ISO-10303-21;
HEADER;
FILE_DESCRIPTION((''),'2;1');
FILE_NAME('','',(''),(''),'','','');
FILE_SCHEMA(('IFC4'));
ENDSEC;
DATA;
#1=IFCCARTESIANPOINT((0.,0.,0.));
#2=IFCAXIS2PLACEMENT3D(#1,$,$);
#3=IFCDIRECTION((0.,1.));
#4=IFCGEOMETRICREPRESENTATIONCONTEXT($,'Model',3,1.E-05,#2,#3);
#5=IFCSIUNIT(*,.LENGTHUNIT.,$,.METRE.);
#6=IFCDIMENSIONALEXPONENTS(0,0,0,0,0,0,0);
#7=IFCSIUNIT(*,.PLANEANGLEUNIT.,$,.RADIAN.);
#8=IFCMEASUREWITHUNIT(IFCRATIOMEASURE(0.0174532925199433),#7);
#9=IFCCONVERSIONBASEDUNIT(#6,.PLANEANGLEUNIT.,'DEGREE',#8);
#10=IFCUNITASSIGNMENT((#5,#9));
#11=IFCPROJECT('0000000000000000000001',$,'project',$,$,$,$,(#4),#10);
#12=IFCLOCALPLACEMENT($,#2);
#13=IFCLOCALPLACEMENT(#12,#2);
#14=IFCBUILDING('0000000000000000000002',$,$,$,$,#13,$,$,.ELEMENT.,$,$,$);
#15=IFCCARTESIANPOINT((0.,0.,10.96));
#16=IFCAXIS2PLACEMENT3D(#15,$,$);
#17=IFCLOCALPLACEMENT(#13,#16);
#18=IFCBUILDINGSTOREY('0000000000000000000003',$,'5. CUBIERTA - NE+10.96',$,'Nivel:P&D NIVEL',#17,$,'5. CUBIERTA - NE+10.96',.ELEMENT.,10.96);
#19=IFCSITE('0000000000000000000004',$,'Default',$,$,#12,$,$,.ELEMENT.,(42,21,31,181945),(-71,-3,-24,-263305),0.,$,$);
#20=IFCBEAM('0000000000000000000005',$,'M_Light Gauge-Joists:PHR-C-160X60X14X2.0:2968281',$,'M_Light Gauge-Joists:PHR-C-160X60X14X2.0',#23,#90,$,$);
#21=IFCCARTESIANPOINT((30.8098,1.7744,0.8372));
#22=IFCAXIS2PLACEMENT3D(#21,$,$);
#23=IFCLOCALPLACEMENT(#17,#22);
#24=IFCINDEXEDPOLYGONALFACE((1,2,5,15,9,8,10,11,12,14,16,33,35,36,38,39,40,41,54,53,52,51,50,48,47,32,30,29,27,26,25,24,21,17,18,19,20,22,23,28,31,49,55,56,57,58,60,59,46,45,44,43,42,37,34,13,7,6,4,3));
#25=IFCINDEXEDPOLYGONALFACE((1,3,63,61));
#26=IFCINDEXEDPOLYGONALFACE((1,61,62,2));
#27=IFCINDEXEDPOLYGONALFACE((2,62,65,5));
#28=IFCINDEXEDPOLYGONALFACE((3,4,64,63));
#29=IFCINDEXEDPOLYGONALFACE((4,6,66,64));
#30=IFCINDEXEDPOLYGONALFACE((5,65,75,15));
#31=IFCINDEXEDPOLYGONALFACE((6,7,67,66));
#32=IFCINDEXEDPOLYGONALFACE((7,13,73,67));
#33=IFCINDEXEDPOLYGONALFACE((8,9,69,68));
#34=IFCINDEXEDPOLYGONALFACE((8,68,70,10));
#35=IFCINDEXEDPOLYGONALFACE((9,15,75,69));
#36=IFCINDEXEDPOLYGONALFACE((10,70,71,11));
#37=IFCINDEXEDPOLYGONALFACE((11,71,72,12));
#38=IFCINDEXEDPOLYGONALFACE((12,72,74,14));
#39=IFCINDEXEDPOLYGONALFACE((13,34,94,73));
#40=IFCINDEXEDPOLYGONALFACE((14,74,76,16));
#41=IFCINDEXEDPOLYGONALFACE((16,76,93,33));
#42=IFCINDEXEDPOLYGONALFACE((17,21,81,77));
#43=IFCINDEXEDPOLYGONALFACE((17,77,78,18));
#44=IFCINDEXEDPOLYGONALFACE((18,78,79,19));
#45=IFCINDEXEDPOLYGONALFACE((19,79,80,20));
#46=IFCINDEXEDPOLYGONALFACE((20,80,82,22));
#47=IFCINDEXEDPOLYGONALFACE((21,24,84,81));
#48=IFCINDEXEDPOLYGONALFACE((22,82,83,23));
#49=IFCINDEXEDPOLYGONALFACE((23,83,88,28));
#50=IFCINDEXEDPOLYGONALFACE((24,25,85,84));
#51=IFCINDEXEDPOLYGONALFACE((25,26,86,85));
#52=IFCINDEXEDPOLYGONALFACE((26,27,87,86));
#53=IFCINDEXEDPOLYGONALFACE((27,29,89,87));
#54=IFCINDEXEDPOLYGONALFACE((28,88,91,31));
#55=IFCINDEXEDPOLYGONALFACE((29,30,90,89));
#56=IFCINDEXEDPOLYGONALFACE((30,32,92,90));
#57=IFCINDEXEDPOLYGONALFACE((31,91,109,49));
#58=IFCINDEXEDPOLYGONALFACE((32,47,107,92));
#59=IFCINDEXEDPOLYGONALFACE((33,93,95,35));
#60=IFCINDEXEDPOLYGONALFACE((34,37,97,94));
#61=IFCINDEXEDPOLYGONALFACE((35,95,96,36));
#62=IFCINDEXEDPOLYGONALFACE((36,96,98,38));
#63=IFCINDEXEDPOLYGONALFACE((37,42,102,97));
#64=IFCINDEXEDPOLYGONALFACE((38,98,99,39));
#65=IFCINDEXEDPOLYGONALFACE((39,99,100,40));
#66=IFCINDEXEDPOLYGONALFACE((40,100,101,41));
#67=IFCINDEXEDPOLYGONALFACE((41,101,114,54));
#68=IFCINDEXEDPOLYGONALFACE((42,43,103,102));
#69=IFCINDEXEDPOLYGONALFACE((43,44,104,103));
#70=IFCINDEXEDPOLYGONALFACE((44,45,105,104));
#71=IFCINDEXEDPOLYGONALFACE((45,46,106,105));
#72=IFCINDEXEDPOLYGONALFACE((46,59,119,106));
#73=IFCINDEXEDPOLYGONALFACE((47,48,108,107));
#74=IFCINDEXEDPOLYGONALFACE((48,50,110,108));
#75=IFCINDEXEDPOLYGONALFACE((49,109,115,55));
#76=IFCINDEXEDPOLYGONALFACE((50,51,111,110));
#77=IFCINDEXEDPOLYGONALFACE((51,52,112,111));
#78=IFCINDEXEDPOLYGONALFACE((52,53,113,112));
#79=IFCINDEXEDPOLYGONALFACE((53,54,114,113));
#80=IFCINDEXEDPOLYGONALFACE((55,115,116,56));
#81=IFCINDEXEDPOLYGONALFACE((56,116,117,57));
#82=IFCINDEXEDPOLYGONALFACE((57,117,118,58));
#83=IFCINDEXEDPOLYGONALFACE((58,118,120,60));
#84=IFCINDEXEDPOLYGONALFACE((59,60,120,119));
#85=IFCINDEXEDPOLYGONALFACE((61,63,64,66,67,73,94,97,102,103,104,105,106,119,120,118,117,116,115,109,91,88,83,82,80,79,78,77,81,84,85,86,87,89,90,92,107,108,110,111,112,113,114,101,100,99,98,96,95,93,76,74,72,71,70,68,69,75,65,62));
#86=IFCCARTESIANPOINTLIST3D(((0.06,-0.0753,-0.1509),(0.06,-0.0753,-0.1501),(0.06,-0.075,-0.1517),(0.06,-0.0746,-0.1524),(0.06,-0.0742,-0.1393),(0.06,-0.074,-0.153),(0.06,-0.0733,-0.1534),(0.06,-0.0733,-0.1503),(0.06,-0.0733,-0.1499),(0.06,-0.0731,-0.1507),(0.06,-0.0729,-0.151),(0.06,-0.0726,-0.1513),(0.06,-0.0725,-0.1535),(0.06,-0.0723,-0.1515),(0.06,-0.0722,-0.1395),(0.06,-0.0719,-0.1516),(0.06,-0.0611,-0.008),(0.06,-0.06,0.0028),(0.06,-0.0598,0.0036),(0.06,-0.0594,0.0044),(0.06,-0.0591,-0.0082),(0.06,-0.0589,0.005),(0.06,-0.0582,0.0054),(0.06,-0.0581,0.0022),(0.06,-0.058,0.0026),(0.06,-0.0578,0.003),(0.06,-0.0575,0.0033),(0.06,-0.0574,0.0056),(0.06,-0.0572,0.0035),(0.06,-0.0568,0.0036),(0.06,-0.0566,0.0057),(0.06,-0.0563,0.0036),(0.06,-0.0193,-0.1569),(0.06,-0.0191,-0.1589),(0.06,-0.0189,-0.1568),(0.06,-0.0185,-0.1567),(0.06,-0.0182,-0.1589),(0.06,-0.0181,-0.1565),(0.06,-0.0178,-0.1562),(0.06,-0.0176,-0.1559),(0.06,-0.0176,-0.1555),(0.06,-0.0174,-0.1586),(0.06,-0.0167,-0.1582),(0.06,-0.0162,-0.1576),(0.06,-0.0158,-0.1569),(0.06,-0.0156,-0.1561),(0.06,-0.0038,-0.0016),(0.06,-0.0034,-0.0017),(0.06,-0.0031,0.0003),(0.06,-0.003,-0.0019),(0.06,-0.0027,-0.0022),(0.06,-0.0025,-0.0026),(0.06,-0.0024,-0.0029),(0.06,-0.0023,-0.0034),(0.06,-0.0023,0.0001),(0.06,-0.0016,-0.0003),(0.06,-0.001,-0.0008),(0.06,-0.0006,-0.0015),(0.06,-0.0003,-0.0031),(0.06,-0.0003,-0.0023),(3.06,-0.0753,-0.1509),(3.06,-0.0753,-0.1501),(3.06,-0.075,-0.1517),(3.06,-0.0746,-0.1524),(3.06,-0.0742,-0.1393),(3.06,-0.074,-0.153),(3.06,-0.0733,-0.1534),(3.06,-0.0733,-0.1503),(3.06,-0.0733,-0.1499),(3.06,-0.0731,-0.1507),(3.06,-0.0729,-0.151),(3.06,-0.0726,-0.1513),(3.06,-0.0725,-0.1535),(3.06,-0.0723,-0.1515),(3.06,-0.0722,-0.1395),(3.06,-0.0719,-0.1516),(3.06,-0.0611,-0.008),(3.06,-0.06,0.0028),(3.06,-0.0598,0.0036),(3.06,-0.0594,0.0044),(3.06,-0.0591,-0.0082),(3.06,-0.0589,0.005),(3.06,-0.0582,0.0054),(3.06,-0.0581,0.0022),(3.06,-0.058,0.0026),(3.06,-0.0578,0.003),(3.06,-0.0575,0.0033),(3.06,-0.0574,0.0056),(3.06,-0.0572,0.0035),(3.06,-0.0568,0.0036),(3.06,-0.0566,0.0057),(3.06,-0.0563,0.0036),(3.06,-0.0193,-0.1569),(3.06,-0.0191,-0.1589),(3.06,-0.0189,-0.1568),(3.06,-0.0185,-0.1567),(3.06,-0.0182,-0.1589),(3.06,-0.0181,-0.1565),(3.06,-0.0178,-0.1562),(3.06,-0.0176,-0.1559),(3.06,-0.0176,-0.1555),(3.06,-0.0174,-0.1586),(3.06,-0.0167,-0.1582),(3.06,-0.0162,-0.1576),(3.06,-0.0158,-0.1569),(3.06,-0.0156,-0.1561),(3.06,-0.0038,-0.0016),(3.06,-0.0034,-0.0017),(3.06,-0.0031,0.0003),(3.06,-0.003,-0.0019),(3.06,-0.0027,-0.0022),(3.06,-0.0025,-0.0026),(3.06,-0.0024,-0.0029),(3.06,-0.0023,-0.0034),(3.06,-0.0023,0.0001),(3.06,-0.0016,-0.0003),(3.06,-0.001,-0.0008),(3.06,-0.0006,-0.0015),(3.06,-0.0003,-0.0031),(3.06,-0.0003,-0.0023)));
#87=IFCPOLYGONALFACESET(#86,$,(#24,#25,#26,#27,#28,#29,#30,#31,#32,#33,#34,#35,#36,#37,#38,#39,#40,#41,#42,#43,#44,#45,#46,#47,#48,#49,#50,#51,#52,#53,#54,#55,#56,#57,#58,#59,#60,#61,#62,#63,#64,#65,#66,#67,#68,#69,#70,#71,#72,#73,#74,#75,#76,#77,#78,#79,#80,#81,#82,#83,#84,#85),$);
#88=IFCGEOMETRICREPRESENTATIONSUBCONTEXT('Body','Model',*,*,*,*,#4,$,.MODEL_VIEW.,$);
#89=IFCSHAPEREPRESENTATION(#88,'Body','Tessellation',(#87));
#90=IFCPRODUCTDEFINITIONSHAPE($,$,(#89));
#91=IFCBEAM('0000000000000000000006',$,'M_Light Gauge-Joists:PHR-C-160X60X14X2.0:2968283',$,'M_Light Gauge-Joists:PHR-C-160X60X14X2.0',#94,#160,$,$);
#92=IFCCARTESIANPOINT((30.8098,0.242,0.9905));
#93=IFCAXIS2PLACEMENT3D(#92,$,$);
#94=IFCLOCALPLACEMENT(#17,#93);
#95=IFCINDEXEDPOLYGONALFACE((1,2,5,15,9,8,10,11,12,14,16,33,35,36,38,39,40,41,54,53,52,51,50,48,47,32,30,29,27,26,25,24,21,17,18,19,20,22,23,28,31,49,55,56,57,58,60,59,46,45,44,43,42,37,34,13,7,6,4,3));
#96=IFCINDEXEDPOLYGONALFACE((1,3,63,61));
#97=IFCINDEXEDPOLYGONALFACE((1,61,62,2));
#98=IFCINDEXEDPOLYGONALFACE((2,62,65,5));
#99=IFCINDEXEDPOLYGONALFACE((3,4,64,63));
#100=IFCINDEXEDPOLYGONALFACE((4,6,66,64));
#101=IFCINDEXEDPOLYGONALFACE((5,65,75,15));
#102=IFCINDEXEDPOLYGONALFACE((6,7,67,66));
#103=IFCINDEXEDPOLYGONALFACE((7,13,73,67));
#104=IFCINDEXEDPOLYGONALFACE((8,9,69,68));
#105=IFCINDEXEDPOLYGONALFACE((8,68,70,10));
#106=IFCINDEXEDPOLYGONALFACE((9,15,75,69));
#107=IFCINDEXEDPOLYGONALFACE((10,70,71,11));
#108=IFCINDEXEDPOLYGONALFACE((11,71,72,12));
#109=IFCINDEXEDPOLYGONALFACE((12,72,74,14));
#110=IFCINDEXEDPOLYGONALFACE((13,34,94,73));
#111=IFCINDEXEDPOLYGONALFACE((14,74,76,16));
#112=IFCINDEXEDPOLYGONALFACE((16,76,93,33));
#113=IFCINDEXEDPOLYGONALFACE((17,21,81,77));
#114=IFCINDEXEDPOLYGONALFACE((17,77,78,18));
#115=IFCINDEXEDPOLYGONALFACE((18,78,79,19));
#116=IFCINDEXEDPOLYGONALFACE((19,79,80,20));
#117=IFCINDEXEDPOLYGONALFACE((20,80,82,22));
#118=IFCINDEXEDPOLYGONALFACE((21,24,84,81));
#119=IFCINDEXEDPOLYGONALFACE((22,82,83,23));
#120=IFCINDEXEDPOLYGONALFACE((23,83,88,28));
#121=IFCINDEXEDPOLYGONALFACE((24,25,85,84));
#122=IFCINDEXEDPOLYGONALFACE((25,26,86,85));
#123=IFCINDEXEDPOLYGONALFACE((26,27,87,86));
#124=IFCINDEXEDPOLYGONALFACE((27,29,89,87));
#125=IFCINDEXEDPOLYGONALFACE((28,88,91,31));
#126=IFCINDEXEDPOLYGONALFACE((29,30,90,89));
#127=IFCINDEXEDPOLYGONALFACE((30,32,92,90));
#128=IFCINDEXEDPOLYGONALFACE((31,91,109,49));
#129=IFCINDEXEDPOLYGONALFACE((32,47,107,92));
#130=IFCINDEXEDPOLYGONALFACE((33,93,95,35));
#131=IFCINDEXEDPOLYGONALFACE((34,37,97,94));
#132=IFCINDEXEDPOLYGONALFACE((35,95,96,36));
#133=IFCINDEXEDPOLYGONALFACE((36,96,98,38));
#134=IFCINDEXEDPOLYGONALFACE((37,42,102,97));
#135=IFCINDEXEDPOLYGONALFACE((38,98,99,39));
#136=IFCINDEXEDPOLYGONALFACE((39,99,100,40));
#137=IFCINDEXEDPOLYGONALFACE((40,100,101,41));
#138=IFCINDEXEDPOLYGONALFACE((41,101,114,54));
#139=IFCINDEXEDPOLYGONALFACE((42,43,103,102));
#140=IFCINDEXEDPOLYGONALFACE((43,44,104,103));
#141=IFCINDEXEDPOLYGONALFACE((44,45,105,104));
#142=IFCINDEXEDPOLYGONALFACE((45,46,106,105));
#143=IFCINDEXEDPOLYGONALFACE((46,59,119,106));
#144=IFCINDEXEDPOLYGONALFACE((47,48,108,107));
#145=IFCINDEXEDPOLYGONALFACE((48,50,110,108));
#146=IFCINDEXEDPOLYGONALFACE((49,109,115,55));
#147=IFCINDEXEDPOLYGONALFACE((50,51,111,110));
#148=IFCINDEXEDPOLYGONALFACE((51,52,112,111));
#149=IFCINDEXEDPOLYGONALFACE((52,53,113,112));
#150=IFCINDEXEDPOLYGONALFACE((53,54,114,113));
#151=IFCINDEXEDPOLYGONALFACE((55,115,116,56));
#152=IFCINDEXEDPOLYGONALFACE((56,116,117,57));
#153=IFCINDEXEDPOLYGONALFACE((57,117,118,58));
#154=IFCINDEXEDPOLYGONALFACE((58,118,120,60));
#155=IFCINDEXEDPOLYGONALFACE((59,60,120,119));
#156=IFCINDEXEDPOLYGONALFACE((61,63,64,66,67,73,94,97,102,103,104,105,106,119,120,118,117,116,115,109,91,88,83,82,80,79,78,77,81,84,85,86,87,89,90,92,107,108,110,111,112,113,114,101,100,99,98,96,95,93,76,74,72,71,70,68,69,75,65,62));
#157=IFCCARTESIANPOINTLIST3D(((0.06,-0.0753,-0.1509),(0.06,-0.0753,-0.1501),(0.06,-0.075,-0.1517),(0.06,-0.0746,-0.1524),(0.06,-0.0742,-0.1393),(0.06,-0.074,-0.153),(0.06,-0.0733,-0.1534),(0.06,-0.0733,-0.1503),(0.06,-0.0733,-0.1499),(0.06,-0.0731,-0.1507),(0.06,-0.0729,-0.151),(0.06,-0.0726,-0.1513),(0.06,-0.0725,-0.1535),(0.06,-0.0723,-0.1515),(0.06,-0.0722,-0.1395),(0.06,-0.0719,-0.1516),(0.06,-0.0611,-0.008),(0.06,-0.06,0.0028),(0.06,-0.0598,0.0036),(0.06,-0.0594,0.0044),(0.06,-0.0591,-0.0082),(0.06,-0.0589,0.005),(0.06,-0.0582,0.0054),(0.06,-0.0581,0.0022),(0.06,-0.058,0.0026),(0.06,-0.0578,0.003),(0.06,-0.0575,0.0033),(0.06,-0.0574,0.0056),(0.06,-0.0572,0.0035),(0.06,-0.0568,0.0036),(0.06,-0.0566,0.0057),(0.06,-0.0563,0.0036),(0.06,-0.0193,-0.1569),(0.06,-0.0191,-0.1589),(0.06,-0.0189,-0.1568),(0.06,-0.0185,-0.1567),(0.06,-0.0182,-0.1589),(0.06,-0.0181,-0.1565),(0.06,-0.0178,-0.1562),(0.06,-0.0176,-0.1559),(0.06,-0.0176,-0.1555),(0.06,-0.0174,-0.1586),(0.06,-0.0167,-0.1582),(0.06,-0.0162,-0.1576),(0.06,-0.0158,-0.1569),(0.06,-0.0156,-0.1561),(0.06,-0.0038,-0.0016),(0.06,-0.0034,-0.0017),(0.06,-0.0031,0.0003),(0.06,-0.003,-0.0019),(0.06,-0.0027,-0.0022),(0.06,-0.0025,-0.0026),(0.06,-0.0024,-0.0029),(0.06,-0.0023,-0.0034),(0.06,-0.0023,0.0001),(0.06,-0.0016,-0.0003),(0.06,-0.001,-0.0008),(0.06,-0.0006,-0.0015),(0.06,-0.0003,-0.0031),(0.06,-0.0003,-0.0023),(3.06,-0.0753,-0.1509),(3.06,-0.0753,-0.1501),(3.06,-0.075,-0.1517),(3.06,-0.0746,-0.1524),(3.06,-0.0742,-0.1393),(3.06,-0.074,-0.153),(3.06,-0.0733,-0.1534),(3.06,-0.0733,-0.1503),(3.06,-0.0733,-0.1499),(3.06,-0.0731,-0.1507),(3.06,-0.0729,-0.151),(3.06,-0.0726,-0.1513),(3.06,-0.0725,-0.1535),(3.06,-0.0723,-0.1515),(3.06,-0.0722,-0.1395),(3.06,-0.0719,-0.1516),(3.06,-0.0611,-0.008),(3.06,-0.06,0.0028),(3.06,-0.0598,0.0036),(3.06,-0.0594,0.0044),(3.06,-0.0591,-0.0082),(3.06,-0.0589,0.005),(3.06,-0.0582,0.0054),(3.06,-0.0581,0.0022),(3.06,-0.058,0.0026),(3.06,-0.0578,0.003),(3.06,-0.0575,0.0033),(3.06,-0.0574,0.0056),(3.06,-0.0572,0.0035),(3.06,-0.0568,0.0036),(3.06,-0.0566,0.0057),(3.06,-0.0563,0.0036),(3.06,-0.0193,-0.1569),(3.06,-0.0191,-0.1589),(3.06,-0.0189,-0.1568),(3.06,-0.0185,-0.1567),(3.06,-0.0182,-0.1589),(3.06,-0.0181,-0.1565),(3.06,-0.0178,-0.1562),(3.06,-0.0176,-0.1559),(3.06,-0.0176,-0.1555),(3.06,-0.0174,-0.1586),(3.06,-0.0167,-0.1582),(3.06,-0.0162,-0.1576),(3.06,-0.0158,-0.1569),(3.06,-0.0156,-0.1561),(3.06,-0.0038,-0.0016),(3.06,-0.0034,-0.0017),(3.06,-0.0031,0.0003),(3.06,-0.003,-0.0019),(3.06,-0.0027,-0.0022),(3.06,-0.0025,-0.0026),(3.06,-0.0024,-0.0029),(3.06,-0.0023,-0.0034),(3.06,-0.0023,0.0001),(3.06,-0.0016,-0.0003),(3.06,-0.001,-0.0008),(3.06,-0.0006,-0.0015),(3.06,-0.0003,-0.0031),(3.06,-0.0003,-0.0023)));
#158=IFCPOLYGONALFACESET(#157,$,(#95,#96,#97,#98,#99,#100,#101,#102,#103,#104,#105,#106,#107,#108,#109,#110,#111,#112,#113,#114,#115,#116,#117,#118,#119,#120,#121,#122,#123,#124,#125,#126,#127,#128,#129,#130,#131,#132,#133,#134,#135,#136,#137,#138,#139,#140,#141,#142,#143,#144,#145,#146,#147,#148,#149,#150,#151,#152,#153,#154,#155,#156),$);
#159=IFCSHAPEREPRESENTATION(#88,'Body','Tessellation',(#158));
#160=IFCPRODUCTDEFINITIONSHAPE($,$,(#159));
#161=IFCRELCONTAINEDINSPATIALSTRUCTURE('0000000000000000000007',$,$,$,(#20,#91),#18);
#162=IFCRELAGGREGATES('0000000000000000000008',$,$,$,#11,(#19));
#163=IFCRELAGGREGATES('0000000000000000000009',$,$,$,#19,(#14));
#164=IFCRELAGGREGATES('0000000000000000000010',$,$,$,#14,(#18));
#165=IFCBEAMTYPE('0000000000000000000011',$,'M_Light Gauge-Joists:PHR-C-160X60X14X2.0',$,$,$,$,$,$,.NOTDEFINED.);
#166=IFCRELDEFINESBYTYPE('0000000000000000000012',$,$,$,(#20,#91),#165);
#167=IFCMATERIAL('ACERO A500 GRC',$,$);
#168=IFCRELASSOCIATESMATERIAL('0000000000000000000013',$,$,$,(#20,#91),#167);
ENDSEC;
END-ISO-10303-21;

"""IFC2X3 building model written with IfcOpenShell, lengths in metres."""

from ifc_helpers import new_model, entity, si_unit, converted_unit, direction, frame, frame_2d, origin, place, context, subcontext, project, spatial, polyline, circle_curve, parameter, trimmed, segment, composite_curve, outline, extrude, material, type_object, element, save


model = new_model("IFC2X3")

# Units and contexts
model_context = context("Model", 3, precision=1e-05, world=origin(), true_north=direction((0.0, 1.0)))
body_context = subcontext(model_context, "Body", "Model", "MODEL_VIEW")
ifc_project = project(units=[si_unit("LENGTHUNIT", "METRE"), converted_unit("PLANEANGLEUNIT", "DEGREE", entity("IfcRatioMeasure", 0.0174532925199433), si_unit("PLANEANGLEUNIT", "RADIAN"), dimensions=[0, 0, 0, 0, 0, 0, 0])], contexts=[model_context])

# Site, building, storey
site_placement = place(None, origin())
site = spatial("IfcSite", under=ifc_project, at=site_placement, Name="Default", CompositionType="ELEMENT", RefLatitude=(42, 21, 31, 181945), RefLongitude=(-71, -3, -24, -263305), RefElevation=0.0)
building_placement = place(site_placement, origin())
building = spatial("IfcBuilding", under=site, at=building_placement, CompositionType="ELEMENT")
storey_placement = place(building_placement, frame((0.0, 0.0, 10.96)))
storey = spatial("IfcBuildingStorey", under=building, at=storey_placement, Name="5. CUBIERTA - NE+10.96", ObjectType="Nivel:P&D NIVEL", LongName="5. CUBIERTA - NE+10.96", CompositionType="ELEMENT", Elevation=10.96)

# Beams
ifc_material_1 = material(Name="ACERO A500 GRC")
beam_type_1 = type_object("IfcBeamType", Name="M_Light Gauge-Joists:PHR-C-160X60X14X2.0", PredefinedType="NOTDEFINED")
beam_1_placement = place(storey_placement, frame((30.8098, 1.7744, 0.8372)))
element("IfcBeam", 1, at=beam_1_placement, inside=storey, type_object=beam_type_1, material=ifc_material_1, Name="M_Light Gauge-Joists:PHR-C-160X60X14X2.0:2968281", ObjectType="M_Light Gauge-Joists:PHR-C-160X60X14X2.0", context=body_context, shape_type="SweptSolid", body=[
    extrude(outline(composite_curve([segment(polyline([(-0.0768, -0.0358), (0.0768, -0.0358)]), True, "CONTINUOUS"), segment(trimmed(circle_curve(frame_2d((0.0768, -0.0326), x_axis=(0.0, -1.0)), 0.0032), [parameter(0.0)], [parameter(90.0)], True, "PARAMETER"), True, "CONTINUOUS"), segment(polyline([(0.08, -0.0326), (0.08, 0.021)]), True, "CONTINUOUS"), segment(trimmed(circle_curve(frame_2d((0.0768, 0.021), x_axis=(1.0, 0.0)), 0.0032), [parameter(0.0)], [parameter(90.0)], True, "PARAMETER"), True, "CONTINUOUS"), segment(polyline([(0.0768, 0.0242), (0.066, 0.0242)]), True, "CONTINUOUS"), segment(polyline([(0.066, 0.0242), (0.066, 0.0222)]), True, "CONTINUOUS"), segment(polyline([(0.066, 0.0222), (0.0764, 0.0222)]), True, "CONTINUOUS"), segment(trimmed(circle_curve(frame_2d((0.0764, 0.0206), x_axis=(0.0, 1.0)), 0.0016), [parameter(270.0)], [parameter(0.0)], True, "PARAMETER"), False, "CONTINUOUS"), segment(polyline([(0.078, 0.0206), (0.078, -0.0322)]), True, "CONTINUOUS"), segment(trimmed(circle_curve(frame_2d((0.0764, -0.0322), x_axis=(1.0, 0.0)), 0.0016), [parameter(270.0)], [parameter(0.0)], True, "PARAMETER"), False, "CONTINUOUS"), segment(polyline([(0.0764, -0.0338), (-0.0764, -0.0338)]), True, "CONTINUOUS"), segment(trimmed(circle_curve(frame_2d((-0.0764, -0.0322), x_axis=(0.0, -1.0)), 0.0016), [parameter(270.0)], [parameter(0.0)], True, "PARAMETER"), False, "CONTINUOUS"), segment(polyline([(-0.078, -0.0322), (-0.078, 0.0206)]), True, "CONTINUOUS"), segment(trimmed(circle_curve(frame_2d((-0.0764, 0.0206), x_axis=(-1.0, 0.0)), 0.0016), [parameter(270.0)], [parameter(0.0)], True, "PARAMETER"), False, "CONTINUOUS"), segment(polyline([(-0.0764, 0.0222), (-0.066, 0.0222)]), True, "CONTINUOUS"), segment(polyline([(-0.066, 0.0222), (-0.066, 0.0242)]), True, "CONTINUOUS"), segment(polyline([(-0.066, 0.0242), (-0.0768, 0.0242)]), True, "CONTINUOUS"), segment(trimmed(circle_curve(frame_2d((-0.0768, 0.021), x_axis=(0.0, 1.0)), 0.0032), [parameter(0.0)], [parameter(90.0)], True, "PARAMETER"), True, "CONTINUOUS"), segment(polyline([(-0.08, 0.021), (-0.08, -0.0326)]), True, "CONTINUOUS"), segment(trimmed(circle_curve(frame_2d((-0.0768, -0.0326), x_axis=(-1.0, 0.0)), 0.0032), [parameter(0.0)], [parameter(90.0)], True, "PARAMETER"), True, "CONTINUOUS")], self_intersect=False)), frame((0.06, -0.0436, -0.076), z_axis=(1.0, 0.0, 0.0), x_axis=(0.0, 0.099504, 0.995037)), (0.0, 0.0, 1.0), 3.0),
])
beam_2_placement = place(storey_placement, frame((30.8098, 0.242, 0.9905)))
element("IfcBeam", 2, at=beam_2_placement, inside=storey, type_object=beam_type_1, material=ifc_material_1, Name="M_Light Gauge-Joists:PHR-C-160X60X14X2.0:2968283", ObjectType="M_Light Gauge-Joists:PHR-C-160X60X14X2.0", context=body_context, shape_type="SweptSolid", body=[
    extrude(outline(composite_curve([segment(polyline([(-0.0768, -0.0358), (0.0768, -0.0358)]), True, "CONTINUOUS"), segment(trimmed(circle_curve(frame_2d((0.0768, -0.0326), x_axis=(0.0, -1.0)), 0.0032), [parameter(0.0)], [parameter(90.0)], True, "PARAMETER"), True, "CONTINUOUS"), segment(polyline([(0.08, -0.0326), (0.08, 0.021)]), True, "CONTINUOUS"), segment(trimmed(circle_curve(frame_2d((0.0768, 0.021), x_axis=(1.0, 0.0)), 0.0032), [parameter(0.0)], [parameter(90.0)], True, "PARAMETER"), True, "CONTINUOUS"), segment(polyline([(0.0768, 0.0242), (0.066, 0.0242)]), True, "CONTINUOUS"), segment(polyline([(0.066, 0.0242), (0.066, 0.0222)]), True, "CONTINUOUS"), segment(polyline([(0.066, 0.0222), (0.0764, 0.0222)]), True, "CONTINUOUS"), segment(trimmed(circle_curve(frame_2d((0.0764, 0.0206), x_axis=(0.0, 1.0)), 0.0016), [parameter(270.0)], [parameter(0.0)], True, "PARAMETER"), False, "CONTINUOUS"), segment(polyline([(0.078, 0.0206), (0.078, -0.0322)]), True, "CONTINUOUS"), segment(trimmed(circle_curve(frame_2d((0.0764, -0.0322), x_axis=(1.0, 0.0)), 0.0016), [parameter(270.0)], [parameter(0.0)], True, "PARAMETER"), False, "CONTINUOUS"), segment(polyline([(0.0764, -0.0338), (-0.0764, -0.0338)]), True, "CONTINUOUS"), segment(trimmed(circle_curve(frame_2d((-0.0764, -0.0322), x_axis=(0.0, -1.0)), 0.0016), [parameter(270.0)], [parameter(0.0)], True, "PARAMETER"), False, "CONTINUOUS"), segment(polyline([(-0.078, -0.0322), (-0.078, 0.0206)]), True, "CONTINUOUS"), segment(trimmed(circle_curve(frame_2d((-0.0764, 0.0206), x_axis=(-1.0, 0.0)), 0.0016), [parameter(270.0)], [parameter(0.0)], True, "PARAMETER"), False, "CONTINUOUS"), segment(polyline([(-0.0764, 0.0222), (-0.066, 0.0222)]), True, "CONTINUOUS"), segment(polyline([(-0.066, 0.0222), (-0.066, 0.0242)]), True, "CONTINUOUS"), segment(polyline([(-0.066, 0.0242), (-0.0768, 0.0242)]), True, "CONTINUOUS"), segment(trimmed(circle_curve(frame_2d((-0.0768, 0.021), x_axis=(0.0, 1.0)), 0.0032), [parameter(0.0)], [parameter(90.0)], True, "PARAMETER"), True, "CONTINUOUS"), segment(polyline([(-0.08, 0.021), (-0.08, -0.0326)]), True, "CONTINUOUS"), segment(trimmed(circle_curve(frame_2d((-0.0768, -0.0326), x_axis=(-1.0, 0.0)), 0.0032), [parameter(0.0)], [parameter(90.0)], True, "PARAMETER"), True, "CONTINUOUS")], self_intersect=False)), frame((0.06, -0.0436, -0.076), z_axis=(1.0, 0.0, 0.0), x_axis=(0.0, 0.099504, 0.995037)), (0.0, 0.0, 1.0), 3.0),
])

save(model, "model.ifc")
